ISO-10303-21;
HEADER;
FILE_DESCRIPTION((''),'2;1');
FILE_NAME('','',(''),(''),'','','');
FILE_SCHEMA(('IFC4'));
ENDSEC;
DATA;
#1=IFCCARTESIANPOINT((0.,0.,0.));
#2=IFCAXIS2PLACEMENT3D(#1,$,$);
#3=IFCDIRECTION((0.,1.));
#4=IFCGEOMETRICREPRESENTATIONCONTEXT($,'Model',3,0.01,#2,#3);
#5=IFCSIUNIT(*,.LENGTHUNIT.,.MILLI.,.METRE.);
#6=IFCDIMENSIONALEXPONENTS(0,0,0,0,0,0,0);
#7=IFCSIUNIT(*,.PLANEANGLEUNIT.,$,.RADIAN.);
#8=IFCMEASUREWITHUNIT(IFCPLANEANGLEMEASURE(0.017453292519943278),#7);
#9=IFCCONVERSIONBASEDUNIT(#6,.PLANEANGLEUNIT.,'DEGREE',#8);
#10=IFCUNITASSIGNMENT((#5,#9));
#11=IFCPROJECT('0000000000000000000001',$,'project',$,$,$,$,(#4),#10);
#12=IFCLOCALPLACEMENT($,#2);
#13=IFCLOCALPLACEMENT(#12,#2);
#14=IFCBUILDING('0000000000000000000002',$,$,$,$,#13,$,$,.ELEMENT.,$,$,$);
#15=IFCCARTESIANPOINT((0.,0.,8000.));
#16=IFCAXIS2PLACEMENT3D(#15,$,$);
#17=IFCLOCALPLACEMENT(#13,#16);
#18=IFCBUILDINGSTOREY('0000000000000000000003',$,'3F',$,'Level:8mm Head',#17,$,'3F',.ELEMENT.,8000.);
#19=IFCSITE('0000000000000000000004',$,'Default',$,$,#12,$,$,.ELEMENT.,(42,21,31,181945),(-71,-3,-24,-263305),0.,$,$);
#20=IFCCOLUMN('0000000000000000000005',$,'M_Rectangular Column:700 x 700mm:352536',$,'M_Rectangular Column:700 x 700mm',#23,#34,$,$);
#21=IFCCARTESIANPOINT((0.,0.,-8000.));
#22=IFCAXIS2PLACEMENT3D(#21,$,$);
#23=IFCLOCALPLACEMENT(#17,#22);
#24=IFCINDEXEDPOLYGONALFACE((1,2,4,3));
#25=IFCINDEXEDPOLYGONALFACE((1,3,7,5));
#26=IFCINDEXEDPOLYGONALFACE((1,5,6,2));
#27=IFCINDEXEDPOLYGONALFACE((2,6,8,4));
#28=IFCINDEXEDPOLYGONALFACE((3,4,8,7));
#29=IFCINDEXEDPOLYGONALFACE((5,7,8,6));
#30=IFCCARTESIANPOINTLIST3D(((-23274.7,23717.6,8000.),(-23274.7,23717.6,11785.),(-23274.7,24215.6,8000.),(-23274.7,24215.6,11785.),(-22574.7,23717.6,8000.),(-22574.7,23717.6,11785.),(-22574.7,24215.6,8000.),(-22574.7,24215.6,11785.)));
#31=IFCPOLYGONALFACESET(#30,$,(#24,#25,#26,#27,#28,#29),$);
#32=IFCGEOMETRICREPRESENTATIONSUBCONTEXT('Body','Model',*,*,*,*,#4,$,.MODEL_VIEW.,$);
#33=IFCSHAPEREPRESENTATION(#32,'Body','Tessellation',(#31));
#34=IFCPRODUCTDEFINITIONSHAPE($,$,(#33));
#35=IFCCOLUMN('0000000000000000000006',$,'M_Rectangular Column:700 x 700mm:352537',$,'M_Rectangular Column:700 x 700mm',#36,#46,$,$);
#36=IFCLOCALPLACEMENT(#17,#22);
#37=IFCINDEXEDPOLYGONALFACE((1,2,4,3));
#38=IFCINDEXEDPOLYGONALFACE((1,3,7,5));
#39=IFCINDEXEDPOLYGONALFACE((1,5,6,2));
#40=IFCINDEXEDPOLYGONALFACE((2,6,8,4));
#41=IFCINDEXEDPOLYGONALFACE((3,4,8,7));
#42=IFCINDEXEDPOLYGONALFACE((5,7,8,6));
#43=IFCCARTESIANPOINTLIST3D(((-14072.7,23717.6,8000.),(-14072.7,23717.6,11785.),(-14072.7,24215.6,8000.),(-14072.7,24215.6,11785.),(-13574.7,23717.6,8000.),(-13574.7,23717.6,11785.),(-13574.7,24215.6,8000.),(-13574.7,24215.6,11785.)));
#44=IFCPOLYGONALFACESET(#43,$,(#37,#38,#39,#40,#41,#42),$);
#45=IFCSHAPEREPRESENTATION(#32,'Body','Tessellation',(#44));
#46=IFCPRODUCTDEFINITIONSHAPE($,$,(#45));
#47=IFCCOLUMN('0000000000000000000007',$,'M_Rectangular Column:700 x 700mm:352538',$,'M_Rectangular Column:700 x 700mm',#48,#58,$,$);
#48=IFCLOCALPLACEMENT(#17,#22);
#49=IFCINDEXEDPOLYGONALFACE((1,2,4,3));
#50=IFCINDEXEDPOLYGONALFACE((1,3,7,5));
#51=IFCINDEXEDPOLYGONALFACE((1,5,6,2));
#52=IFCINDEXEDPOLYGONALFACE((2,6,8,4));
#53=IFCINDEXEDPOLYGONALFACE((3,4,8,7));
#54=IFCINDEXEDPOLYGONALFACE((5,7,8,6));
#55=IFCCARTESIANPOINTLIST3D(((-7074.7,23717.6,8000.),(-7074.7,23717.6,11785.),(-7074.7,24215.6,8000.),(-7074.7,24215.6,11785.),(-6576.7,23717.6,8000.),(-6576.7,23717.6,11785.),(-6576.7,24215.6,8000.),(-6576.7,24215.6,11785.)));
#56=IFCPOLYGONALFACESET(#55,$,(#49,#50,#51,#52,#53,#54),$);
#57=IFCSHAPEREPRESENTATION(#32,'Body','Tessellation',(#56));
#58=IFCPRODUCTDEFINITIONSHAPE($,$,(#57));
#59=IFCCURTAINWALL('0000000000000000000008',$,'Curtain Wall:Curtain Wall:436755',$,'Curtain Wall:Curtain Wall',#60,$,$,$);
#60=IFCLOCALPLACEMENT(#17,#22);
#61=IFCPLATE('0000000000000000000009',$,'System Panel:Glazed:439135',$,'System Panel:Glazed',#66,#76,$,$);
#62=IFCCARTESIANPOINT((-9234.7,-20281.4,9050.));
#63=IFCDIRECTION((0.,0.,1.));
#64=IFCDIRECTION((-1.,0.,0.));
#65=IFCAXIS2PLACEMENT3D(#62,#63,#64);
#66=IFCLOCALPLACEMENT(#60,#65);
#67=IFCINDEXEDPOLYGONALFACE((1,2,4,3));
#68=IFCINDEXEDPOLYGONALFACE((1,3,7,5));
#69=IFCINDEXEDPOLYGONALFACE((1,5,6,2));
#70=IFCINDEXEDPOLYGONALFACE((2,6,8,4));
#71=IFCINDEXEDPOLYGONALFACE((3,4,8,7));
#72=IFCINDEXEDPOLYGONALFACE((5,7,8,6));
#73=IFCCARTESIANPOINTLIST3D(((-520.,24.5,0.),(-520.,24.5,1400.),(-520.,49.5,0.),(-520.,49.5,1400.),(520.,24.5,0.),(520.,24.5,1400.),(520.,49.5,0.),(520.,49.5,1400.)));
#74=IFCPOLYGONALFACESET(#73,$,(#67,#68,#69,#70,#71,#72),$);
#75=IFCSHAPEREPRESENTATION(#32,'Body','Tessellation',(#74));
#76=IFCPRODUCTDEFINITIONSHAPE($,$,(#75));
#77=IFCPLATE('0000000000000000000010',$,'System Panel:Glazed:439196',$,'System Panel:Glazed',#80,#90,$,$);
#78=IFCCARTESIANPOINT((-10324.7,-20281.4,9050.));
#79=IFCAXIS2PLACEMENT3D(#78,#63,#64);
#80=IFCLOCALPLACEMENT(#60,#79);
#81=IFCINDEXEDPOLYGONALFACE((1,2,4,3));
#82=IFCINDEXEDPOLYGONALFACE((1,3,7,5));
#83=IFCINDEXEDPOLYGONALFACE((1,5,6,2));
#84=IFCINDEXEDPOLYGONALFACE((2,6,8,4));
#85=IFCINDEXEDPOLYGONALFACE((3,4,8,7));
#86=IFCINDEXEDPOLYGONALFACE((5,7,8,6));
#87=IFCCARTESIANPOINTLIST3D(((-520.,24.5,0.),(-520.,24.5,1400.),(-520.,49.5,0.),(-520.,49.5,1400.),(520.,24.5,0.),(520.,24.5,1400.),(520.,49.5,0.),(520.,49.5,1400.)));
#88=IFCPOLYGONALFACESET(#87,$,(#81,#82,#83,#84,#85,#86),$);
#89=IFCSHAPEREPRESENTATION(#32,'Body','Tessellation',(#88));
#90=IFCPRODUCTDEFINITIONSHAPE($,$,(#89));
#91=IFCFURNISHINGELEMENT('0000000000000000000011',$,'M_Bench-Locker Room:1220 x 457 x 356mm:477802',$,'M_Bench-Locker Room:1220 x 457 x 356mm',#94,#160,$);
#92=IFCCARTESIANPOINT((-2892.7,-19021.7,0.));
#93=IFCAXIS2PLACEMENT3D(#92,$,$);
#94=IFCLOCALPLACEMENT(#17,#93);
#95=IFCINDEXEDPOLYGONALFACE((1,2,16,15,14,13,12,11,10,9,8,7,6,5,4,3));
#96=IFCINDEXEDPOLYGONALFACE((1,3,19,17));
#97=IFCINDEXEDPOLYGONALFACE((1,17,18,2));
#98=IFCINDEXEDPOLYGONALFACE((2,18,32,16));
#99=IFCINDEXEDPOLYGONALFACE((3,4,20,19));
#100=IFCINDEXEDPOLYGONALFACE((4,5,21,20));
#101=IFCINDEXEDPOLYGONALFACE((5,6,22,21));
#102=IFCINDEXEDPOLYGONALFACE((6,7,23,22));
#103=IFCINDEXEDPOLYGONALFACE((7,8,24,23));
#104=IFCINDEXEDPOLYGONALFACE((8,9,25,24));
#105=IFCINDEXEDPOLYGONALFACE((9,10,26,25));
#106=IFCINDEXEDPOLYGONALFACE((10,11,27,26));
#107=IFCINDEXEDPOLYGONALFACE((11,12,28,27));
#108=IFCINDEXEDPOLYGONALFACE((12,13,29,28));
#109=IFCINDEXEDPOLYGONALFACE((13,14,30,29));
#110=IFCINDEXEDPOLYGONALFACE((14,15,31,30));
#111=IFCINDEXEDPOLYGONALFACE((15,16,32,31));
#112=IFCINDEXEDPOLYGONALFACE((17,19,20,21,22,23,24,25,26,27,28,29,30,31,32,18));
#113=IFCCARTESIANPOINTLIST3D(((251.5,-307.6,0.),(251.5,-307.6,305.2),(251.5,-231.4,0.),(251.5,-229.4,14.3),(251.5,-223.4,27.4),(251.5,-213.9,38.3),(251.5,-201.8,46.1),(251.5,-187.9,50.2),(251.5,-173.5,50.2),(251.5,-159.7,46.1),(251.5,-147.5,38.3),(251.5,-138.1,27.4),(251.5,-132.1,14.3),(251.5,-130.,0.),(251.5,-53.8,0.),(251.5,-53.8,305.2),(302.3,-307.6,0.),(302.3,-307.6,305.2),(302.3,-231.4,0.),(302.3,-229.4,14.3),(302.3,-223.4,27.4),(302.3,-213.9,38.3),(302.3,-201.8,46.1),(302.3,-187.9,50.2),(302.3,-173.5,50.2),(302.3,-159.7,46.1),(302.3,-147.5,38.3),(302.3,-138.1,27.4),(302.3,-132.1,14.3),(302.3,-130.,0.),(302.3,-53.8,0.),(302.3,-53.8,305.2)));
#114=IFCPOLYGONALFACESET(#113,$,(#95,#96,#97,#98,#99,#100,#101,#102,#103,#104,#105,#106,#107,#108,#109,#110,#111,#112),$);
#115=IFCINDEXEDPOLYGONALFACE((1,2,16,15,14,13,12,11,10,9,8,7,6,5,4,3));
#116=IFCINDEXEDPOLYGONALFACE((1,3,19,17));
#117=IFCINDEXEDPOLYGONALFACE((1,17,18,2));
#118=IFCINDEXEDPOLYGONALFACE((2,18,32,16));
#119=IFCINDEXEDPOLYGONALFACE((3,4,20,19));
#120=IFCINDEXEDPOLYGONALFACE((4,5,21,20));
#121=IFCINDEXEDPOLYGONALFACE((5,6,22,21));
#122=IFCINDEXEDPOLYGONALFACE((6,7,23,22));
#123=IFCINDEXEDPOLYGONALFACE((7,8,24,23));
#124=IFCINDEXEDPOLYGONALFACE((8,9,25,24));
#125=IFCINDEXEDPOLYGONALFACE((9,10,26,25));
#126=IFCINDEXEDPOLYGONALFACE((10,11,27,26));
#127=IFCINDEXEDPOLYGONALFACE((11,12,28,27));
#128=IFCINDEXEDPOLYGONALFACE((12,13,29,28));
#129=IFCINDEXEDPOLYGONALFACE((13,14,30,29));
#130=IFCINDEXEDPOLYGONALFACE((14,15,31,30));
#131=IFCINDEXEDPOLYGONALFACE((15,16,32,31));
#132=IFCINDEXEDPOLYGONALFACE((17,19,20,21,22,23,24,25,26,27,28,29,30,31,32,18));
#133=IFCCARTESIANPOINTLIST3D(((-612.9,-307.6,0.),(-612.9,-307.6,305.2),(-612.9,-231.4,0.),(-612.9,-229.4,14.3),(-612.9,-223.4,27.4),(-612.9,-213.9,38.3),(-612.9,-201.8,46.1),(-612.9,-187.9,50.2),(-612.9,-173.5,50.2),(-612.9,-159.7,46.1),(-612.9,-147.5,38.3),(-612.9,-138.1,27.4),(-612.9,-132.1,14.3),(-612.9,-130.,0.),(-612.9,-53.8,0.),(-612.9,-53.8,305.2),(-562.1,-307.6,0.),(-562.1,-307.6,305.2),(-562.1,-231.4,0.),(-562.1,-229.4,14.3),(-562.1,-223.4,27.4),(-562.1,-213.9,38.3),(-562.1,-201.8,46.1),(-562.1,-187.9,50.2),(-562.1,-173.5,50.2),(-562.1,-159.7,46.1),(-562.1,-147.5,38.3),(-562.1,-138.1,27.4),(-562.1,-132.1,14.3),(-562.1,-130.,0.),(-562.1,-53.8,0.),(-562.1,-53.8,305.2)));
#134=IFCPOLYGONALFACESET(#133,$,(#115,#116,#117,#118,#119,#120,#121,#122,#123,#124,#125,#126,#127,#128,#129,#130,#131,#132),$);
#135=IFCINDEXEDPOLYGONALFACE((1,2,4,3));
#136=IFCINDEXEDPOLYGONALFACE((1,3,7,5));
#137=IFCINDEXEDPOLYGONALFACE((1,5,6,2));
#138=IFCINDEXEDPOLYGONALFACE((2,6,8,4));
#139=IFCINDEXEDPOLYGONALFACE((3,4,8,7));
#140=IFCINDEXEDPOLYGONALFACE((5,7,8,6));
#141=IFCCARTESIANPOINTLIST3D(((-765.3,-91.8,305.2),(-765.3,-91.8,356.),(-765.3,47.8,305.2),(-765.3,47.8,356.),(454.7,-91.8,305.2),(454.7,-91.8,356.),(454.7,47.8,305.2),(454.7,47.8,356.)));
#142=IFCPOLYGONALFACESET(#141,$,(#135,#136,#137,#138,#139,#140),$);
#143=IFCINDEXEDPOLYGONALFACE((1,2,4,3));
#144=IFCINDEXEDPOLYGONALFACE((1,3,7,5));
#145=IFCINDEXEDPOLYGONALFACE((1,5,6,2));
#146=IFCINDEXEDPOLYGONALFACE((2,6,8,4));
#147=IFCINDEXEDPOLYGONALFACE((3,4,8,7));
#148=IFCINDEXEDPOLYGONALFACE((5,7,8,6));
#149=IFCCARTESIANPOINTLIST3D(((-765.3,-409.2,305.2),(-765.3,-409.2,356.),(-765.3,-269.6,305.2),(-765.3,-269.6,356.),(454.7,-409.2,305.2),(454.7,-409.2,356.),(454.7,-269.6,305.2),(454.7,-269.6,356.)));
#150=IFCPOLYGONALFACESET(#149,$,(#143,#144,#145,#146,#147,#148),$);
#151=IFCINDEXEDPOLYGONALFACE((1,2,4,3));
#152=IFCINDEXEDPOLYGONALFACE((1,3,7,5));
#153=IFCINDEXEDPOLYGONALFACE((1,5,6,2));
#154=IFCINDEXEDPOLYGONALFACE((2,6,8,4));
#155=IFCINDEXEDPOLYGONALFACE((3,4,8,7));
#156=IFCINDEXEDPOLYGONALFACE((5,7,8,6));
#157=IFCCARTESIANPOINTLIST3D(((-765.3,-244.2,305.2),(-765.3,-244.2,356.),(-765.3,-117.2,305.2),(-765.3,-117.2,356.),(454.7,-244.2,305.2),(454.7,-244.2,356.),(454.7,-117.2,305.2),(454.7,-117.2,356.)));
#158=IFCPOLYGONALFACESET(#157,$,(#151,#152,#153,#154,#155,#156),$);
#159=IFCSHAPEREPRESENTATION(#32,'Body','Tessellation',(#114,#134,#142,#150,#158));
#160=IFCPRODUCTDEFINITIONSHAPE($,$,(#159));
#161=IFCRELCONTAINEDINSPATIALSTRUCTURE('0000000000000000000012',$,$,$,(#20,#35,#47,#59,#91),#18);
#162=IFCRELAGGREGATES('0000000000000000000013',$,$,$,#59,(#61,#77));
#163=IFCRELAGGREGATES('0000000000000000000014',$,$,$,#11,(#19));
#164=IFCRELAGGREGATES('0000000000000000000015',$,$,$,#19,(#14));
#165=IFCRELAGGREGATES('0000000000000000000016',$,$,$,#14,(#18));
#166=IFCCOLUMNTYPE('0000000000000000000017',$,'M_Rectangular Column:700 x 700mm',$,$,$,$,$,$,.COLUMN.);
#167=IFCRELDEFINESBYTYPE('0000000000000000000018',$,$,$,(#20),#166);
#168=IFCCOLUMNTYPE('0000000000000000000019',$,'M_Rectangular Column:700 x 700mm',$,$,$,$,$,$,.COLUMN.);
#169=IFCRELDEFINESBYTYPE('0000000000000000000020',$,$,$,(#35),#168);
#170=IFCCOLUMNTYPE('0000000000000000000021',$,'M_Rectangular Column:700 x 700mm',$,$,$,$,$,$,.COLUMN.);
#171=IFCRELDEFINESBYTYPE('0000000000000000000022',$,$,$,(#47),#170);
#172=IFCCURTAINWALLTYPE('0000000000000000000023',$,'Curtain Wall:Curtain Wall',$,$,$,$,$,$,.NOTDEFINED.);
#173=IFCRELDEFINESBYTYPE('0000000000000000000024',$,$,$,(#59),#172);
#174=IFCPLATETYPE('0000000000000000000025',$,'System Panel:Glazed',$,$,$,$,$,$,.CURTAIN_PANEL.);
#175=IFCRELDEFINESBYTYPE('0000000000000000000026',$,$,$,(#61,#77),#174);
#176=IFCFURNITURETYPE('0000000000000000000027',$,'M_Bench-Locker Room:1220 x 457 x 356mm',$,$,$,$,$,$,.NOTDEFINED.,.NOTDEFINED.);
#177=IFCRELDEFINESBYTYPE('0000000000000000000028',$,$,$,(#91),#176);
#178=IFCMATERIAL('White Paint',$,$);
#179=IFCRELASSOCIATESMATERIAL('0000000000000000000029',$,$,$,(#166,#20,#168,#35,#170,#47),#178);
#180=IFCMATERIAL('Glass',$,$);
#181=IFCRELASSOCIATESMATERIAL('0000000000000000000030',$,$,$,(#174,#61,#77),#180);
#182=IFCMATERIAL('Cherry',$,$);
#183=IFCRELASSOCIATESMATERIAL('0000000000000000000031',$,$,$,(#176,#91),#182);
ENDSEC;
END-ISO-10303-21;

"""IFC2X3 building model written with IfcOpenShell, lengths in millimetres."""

from ifc_helpers import new_model, entity, si_unit, converted_unit, direction, frame, frame_2d, origin, origin_2d_with_axis, place, context, subcontext, project, spatial, polyline, circle_curve, parameter, trimmed, segment, composite_curve, rectangle, outline, extrude, source, transform, mapped, material, type_object, type_shapes, element, aggregate, save


model = new_model("IFC2X3")

# Units and contexts
model_context = context("Model", 3, precision=0.01, world=origin(), true_north=direction((0.0, 1.0)))
body_context = subcontext(model_context, "Body", "Model", "MODEL_VIEW")
ifc_project = project(units=[si_unit("LENGTHUNIT", "METRE", prefix="MILLI"), converted_unit("PLANEANGLEUNIT", "DEGREE", entity("IfcPlaneAngleMeasure", 0.017453292519943278), si_unit("PLANEANGLEUNIT", "RADIAN"), dimensions=[0, 0, 0, 0, 0, 0, 0])], contexts=[model_context])

# Site, building, storey
site_placement = place(None, origin())
site = spatial("IfcSite", under=ifc_project, at=site_placement, Name="Default", CompositionType="ELEMENT", RefLatitude=(42, 21, 31, 181945), RefLongitude=(-71, -3, -24, -263305), RefElevation=0.0)
building_placement = place(site_placement, origin())
building = spatial("IfcBuilding", under=site, at=building_placement, CompositionType="ELEMENT")
storey_placement = place(building_placement, frame((0.0, 0.0, 8000.0)))
storey = spatial("IfcBuildingStorey", under=building, at=storey_placement, Name="3F", ObjectType="Level:8mm Head", LongName="3F", CompositionType="ELEMENT", Elevation=8000.0)

# Columns
ifc_material_1 = material(Name="White Paint")
column_type_1 = type_object("IfcColumnType", Name="M_Rectangular Column:700 x 700mm", PredefinedType="COLUMN", material=ifc_material_1)
shared_shape_1 = source(origin(), body_context, "Body", "SweptSolid", [
    extrude(rectangle(XDim=3785.0, YDim=498.0, at=frame_2d((0.0, 0.0), x_axis=(1.0, 0.0))), frame((-23274.7, 23966.6, 9892.5), z_axis=(1.0, 0.0, 0.0), x_axis=(0.0, 0.0, 1.0)), (0.0, 0.0, 1.0), 700.0),
])
type_shapes(column_type_1, [shared_shape_1])
column_1_placement = place(storey_placement, frame((0.0, 0.0, -8000.0)))
element("IfcColumn", 1, at=column_1_placement, inside=storey, type_object=column_type_1, material=ifc_material_1, Name="M_Rectangular Column:700 x 700mm:352536", ObjectType="M_Rectangular Column:700 x 700mm", context=body_context, shape_type="MappedRepresentation", body=[
    mapped(shared_shape_1, transform((0.0, 0.0, 0.0), scale=1.0)),
])
column_type_2 = type_object("IfcColumnType", Name="M_Rectangular Column:700 x 700mm", PredefinedType="COLUMN", material=ifc_material_1)
shared_shape_2 = source(origin(), body_context, "Body", "SweptSolid", [
    extrude(rectangle(XDim=498.0, YDim=498.0, at=frame_2d((0.0, 0.0), x_axis=(1.0, 0.0))), frame((-13823.7, 23966.6, 8000.0), z_axis=(0.0, 0.0, 1.0), x_axis=(0.0, 1.0, 0.0)), (0.0, 0.0, 1.0), 3785.0),
])
type_shapes(column_type_2, [shared_shape_2])
column_2_placement = place(storey_placement, frame((0.0, 0.0, -8000.0)))
element("IfcColumn", 2, at=column_2_placement, inside=storey, type_object=column_type_2, material=ifc_material_1, Name="M_Rectangular Column:700 x 700mm:352537", ObjectType="M_Rectangular Column:700 x 700mm", context=body_context, shape_type="MappedRepresentation", body=[
    mapped(shared_shape_2, transform((0.0, 0.0, 0.0), scale=1.0)),
])
column_type_3 = type_object("IfcColumnType", Name="M_Rectangular Column:700 x 700mm", PredefinedType="COLUMN", material=ifc_material_1)
shared_shape_3 = source(origin(), body_context, "Body", "SweptSolid", [
    extrude(rectangle(XDim=498.0, YDim=498.0, at=frame_2d((0.0, 0.0), x_axis=(1.0, 0.0))), frame((-6825.7, 23966.6, 8000.0)), (0.0, 0.0, 1.0), 3785.0),
])
type_shapes(column_type_3, [shared_shape_3])
column_3_placement = place(storey_placement, frame((0.0, 0.0, -8000.0)))
element("IfcColumn", 3, at=column_3_placement, inside=storey, type_object=column_type_3, material=ifc_material_1, Name="M_Rectangular Column:700 x 700mm:352538", ObjectType="M_Rectangular Column:700 x 700mm", context=body_context, shape_type="MappedRepresentation", body=[
    mapped(shared_shape_3, transform((0.0, 0.0, 0.0), scale=1.0)),
])

# Curtain wall, plates
curtain_wall_type = type_object("IfcCurtainWallType", Name="Curtain Wall:Curtain Wall", PredefinedType="NOTDEFINED")
curtain_wall_placement = place(storey_placement, frame((0.0, 0.0, -8000.0)))
curtain_wall = element("IfcCurtainWall", 4, at=curtain_wall_placement, inside=storey, type_object=curtain_wall_type, Name="Curtain Wall:Curtain Wall:436755", ObjectType="Curtain Wall:Curtain Wall")
ifc_material_2 = material(Name="Glass")
plate_type = type_object("IfcPlateType", Name="System Panel:Glazed", PredefinedType="CURTAIN_PANEL", material=ifc_material_2)
shared_shape_4 = source(origin(), body_context, "Body", "SweptSolid", [
    extrude(rectangle(XDim=25.0, YDim=1040.0, at=origin_2d_with_axis()), frame((0.0, 37.0, 0.0), z_axis=(0.0, 0.0, 1.0), x_axis=(0.0, 1.0, 0.0)), (0.0, 0.0, 1.0), 1400.0),
])
type_shapes(plate_type, [shared_shape_4])
plate_1_placement = place(curtain_wall_placement, frame((-9234.7, -20281.4, 9050.0), z_axis=(0.0, 0.0, 1.0), x_axis=(-1.0, 0.0, 0.0)))
plate_1 = element("IfcPlate", 5, at=plate_1_placement, type_object=plate_type, material=ifc_material_2, Name="System Panel:Glazed:439135", ObjectType="System Panel:Glazed", context=body_context, shape_type="MappedRepresentation", body=[
    mapped(shared_shape_4, transform((0.0, 0.0, 0.0), scale=1.0)),
])
plate_2_placement = place(curtain_wall_placement, frame((-10324.7, -20281.4, 9050.0), z_axis=(0.0, 0.0, 1.0), x_axis=(-1.0, 0.0, 0.0)))
plate_2 = element("IfcPlate", 6, at=plate_2_placement, type_object=plate_type, material=ifc_material_2, Name="System Panel:Glazed:439196", ObjectType="System Panel:Glazed", context=body_context, shape_type="MappedRepresentation", body=[
    mapped(shared_shape_4, transform((0.0, 0.0, 0.0), scale=1.0)),
])
aggregate(curtain_wall, [plate_1, plate_2])

# Furnishing element
ifc_material_3 = material(Name="Cherry")
furniture_type = type_object("IfcFurnitureType", Name="M_Bench-Locker Room:1220 x 457 x 356mm", AssemblyPlace="NOTDEFINED", material=ifc_material_3)
shared_shape_5 = source(origin(), body_context, "Body", "SweptSolid", [
    extrude(outline(composite_curve([segment(polyline([(-126.9, 101.7), (-126.9, -203.5)]), True, "CONTINUOUS"), segment(polyline([(-126.9, -203.5), (126.9, -203.5)]), True, "CONTINUOUS"), segment(polyline([(126.9, -203.5), (126.9, 101.7)]), True, "CONTINUOUS"), segment(polyline([(126.9, 101.7), (50.7, 101.7)]), True, "CONTINUOUS"), segment(trimmed(circle_curve(frame_2d((0.0, 101.7), x_axis=(0.0, 1.0)), 50.7), [parameter(90.0)], [parameter(270.0)], True, "PARAMETER"), False, "CONTINUOUS"), segment(polyline([(-50.7, 101.7), (-126.9, 101.7)]), True, "CONTINUOUS")], self_intersect=False)), frame((251.5, -180.7, 101.7), z_axis=(-1.0, 0.0, 0.0), x_axis=(0.0, 1.0, 0.0)), (0.0, 0.0, -1.0), 50.8),
    extrude(outline(composite_curve([segment(polyline([(-101.7, -126.9), (203.5, -126.9)]), True, "CONTINUOUS"), segment(polyline([(203.5, -126.9), (203.5, 126.9)]), True, "CONTINUOUS"), segment(polyline([(203.5, 126.9), (-101.7, 126.9)]), True, "CONTINUOUS"), segment(polyline([(-101.7, 126.9), (-101.7, 50.7)]), True, "CONTINUOUS"), segment(trimmed(circle_curve(frame_2d((-101.7, 0.0), x_axis=(-1.0, 0.0)), 50.7), [parameter(90.0)], [parameter(270.0)], True, "PARAMETER"), False, "CONTINUOUS"), segment(polyline([(-101.7, -50.7), (-101.7, -126.9)]), True, "CONTINUOUS")], self_intersect=False)), frame((-612.9, -180.7, 101.7), z_axis=(1.0, 0.0, 0.0), x_axis=(0.0, 0.0, 1.0)), (0.0, 0.0, 1.0), 50.8),
    extrude(rectangle(XDim=1220.0, YDim=139.6, at=origin_2d_with_axis()), frame((-155.3, -22.0, 305.2), z_axis=(0.0, 0.0, 1.0), x_axis=(-1.0, 0.0, 0.0)), (0.0, 0.0, 1.0), 50.8),
    extrude(rectangle(XDim=139.6, YDim=1220.0, at=frame_2d((0.0, 0.0), x_axis=(1.0, 0.0))), frame((-155.3, -339.4, 305.2), z_axis=(0.0, 0.0, 1.0), x_axis=(0.0, 1.0, 0.0)), (0.0, 0.0, 1.0), 50.8),
    extrude(rectangle(XDim=1220.0, YDim=126.9, at=frame_2d((0.0, 0.0), x_axis=(1.0, 0.0))), frame((-155.3, -180.7, 305.2), z_axis=(0.0, 0.0, 1.0), x_axis=(-1.0, 0.0, 0.0)), (0.0, 0.0, 1.0), 50.8),
])
type_shapes(furniture_type, [shared_shape_5])
furnishing_placement = place(storey_placement, frame((-2892.7, -19021.7, 0.0)))
element("IfcFurnishingElement", 7, at=furnishing_placement, inside=storey, type_object=furniture_type, material=ifc_material_3, Name="M_Bench-Locker Room:1220 x 457 x 356mm:477802", ObjectType="M_Bench-Locker Room:1220 x 457 x 356mm", context=body_context, shape_type="MappedRepresentation", body=[
    mapped(shared_shape_5, transform((0.0, 0.0, 0.0), scale=1.0)),
])

save(model, "model.ifc")
